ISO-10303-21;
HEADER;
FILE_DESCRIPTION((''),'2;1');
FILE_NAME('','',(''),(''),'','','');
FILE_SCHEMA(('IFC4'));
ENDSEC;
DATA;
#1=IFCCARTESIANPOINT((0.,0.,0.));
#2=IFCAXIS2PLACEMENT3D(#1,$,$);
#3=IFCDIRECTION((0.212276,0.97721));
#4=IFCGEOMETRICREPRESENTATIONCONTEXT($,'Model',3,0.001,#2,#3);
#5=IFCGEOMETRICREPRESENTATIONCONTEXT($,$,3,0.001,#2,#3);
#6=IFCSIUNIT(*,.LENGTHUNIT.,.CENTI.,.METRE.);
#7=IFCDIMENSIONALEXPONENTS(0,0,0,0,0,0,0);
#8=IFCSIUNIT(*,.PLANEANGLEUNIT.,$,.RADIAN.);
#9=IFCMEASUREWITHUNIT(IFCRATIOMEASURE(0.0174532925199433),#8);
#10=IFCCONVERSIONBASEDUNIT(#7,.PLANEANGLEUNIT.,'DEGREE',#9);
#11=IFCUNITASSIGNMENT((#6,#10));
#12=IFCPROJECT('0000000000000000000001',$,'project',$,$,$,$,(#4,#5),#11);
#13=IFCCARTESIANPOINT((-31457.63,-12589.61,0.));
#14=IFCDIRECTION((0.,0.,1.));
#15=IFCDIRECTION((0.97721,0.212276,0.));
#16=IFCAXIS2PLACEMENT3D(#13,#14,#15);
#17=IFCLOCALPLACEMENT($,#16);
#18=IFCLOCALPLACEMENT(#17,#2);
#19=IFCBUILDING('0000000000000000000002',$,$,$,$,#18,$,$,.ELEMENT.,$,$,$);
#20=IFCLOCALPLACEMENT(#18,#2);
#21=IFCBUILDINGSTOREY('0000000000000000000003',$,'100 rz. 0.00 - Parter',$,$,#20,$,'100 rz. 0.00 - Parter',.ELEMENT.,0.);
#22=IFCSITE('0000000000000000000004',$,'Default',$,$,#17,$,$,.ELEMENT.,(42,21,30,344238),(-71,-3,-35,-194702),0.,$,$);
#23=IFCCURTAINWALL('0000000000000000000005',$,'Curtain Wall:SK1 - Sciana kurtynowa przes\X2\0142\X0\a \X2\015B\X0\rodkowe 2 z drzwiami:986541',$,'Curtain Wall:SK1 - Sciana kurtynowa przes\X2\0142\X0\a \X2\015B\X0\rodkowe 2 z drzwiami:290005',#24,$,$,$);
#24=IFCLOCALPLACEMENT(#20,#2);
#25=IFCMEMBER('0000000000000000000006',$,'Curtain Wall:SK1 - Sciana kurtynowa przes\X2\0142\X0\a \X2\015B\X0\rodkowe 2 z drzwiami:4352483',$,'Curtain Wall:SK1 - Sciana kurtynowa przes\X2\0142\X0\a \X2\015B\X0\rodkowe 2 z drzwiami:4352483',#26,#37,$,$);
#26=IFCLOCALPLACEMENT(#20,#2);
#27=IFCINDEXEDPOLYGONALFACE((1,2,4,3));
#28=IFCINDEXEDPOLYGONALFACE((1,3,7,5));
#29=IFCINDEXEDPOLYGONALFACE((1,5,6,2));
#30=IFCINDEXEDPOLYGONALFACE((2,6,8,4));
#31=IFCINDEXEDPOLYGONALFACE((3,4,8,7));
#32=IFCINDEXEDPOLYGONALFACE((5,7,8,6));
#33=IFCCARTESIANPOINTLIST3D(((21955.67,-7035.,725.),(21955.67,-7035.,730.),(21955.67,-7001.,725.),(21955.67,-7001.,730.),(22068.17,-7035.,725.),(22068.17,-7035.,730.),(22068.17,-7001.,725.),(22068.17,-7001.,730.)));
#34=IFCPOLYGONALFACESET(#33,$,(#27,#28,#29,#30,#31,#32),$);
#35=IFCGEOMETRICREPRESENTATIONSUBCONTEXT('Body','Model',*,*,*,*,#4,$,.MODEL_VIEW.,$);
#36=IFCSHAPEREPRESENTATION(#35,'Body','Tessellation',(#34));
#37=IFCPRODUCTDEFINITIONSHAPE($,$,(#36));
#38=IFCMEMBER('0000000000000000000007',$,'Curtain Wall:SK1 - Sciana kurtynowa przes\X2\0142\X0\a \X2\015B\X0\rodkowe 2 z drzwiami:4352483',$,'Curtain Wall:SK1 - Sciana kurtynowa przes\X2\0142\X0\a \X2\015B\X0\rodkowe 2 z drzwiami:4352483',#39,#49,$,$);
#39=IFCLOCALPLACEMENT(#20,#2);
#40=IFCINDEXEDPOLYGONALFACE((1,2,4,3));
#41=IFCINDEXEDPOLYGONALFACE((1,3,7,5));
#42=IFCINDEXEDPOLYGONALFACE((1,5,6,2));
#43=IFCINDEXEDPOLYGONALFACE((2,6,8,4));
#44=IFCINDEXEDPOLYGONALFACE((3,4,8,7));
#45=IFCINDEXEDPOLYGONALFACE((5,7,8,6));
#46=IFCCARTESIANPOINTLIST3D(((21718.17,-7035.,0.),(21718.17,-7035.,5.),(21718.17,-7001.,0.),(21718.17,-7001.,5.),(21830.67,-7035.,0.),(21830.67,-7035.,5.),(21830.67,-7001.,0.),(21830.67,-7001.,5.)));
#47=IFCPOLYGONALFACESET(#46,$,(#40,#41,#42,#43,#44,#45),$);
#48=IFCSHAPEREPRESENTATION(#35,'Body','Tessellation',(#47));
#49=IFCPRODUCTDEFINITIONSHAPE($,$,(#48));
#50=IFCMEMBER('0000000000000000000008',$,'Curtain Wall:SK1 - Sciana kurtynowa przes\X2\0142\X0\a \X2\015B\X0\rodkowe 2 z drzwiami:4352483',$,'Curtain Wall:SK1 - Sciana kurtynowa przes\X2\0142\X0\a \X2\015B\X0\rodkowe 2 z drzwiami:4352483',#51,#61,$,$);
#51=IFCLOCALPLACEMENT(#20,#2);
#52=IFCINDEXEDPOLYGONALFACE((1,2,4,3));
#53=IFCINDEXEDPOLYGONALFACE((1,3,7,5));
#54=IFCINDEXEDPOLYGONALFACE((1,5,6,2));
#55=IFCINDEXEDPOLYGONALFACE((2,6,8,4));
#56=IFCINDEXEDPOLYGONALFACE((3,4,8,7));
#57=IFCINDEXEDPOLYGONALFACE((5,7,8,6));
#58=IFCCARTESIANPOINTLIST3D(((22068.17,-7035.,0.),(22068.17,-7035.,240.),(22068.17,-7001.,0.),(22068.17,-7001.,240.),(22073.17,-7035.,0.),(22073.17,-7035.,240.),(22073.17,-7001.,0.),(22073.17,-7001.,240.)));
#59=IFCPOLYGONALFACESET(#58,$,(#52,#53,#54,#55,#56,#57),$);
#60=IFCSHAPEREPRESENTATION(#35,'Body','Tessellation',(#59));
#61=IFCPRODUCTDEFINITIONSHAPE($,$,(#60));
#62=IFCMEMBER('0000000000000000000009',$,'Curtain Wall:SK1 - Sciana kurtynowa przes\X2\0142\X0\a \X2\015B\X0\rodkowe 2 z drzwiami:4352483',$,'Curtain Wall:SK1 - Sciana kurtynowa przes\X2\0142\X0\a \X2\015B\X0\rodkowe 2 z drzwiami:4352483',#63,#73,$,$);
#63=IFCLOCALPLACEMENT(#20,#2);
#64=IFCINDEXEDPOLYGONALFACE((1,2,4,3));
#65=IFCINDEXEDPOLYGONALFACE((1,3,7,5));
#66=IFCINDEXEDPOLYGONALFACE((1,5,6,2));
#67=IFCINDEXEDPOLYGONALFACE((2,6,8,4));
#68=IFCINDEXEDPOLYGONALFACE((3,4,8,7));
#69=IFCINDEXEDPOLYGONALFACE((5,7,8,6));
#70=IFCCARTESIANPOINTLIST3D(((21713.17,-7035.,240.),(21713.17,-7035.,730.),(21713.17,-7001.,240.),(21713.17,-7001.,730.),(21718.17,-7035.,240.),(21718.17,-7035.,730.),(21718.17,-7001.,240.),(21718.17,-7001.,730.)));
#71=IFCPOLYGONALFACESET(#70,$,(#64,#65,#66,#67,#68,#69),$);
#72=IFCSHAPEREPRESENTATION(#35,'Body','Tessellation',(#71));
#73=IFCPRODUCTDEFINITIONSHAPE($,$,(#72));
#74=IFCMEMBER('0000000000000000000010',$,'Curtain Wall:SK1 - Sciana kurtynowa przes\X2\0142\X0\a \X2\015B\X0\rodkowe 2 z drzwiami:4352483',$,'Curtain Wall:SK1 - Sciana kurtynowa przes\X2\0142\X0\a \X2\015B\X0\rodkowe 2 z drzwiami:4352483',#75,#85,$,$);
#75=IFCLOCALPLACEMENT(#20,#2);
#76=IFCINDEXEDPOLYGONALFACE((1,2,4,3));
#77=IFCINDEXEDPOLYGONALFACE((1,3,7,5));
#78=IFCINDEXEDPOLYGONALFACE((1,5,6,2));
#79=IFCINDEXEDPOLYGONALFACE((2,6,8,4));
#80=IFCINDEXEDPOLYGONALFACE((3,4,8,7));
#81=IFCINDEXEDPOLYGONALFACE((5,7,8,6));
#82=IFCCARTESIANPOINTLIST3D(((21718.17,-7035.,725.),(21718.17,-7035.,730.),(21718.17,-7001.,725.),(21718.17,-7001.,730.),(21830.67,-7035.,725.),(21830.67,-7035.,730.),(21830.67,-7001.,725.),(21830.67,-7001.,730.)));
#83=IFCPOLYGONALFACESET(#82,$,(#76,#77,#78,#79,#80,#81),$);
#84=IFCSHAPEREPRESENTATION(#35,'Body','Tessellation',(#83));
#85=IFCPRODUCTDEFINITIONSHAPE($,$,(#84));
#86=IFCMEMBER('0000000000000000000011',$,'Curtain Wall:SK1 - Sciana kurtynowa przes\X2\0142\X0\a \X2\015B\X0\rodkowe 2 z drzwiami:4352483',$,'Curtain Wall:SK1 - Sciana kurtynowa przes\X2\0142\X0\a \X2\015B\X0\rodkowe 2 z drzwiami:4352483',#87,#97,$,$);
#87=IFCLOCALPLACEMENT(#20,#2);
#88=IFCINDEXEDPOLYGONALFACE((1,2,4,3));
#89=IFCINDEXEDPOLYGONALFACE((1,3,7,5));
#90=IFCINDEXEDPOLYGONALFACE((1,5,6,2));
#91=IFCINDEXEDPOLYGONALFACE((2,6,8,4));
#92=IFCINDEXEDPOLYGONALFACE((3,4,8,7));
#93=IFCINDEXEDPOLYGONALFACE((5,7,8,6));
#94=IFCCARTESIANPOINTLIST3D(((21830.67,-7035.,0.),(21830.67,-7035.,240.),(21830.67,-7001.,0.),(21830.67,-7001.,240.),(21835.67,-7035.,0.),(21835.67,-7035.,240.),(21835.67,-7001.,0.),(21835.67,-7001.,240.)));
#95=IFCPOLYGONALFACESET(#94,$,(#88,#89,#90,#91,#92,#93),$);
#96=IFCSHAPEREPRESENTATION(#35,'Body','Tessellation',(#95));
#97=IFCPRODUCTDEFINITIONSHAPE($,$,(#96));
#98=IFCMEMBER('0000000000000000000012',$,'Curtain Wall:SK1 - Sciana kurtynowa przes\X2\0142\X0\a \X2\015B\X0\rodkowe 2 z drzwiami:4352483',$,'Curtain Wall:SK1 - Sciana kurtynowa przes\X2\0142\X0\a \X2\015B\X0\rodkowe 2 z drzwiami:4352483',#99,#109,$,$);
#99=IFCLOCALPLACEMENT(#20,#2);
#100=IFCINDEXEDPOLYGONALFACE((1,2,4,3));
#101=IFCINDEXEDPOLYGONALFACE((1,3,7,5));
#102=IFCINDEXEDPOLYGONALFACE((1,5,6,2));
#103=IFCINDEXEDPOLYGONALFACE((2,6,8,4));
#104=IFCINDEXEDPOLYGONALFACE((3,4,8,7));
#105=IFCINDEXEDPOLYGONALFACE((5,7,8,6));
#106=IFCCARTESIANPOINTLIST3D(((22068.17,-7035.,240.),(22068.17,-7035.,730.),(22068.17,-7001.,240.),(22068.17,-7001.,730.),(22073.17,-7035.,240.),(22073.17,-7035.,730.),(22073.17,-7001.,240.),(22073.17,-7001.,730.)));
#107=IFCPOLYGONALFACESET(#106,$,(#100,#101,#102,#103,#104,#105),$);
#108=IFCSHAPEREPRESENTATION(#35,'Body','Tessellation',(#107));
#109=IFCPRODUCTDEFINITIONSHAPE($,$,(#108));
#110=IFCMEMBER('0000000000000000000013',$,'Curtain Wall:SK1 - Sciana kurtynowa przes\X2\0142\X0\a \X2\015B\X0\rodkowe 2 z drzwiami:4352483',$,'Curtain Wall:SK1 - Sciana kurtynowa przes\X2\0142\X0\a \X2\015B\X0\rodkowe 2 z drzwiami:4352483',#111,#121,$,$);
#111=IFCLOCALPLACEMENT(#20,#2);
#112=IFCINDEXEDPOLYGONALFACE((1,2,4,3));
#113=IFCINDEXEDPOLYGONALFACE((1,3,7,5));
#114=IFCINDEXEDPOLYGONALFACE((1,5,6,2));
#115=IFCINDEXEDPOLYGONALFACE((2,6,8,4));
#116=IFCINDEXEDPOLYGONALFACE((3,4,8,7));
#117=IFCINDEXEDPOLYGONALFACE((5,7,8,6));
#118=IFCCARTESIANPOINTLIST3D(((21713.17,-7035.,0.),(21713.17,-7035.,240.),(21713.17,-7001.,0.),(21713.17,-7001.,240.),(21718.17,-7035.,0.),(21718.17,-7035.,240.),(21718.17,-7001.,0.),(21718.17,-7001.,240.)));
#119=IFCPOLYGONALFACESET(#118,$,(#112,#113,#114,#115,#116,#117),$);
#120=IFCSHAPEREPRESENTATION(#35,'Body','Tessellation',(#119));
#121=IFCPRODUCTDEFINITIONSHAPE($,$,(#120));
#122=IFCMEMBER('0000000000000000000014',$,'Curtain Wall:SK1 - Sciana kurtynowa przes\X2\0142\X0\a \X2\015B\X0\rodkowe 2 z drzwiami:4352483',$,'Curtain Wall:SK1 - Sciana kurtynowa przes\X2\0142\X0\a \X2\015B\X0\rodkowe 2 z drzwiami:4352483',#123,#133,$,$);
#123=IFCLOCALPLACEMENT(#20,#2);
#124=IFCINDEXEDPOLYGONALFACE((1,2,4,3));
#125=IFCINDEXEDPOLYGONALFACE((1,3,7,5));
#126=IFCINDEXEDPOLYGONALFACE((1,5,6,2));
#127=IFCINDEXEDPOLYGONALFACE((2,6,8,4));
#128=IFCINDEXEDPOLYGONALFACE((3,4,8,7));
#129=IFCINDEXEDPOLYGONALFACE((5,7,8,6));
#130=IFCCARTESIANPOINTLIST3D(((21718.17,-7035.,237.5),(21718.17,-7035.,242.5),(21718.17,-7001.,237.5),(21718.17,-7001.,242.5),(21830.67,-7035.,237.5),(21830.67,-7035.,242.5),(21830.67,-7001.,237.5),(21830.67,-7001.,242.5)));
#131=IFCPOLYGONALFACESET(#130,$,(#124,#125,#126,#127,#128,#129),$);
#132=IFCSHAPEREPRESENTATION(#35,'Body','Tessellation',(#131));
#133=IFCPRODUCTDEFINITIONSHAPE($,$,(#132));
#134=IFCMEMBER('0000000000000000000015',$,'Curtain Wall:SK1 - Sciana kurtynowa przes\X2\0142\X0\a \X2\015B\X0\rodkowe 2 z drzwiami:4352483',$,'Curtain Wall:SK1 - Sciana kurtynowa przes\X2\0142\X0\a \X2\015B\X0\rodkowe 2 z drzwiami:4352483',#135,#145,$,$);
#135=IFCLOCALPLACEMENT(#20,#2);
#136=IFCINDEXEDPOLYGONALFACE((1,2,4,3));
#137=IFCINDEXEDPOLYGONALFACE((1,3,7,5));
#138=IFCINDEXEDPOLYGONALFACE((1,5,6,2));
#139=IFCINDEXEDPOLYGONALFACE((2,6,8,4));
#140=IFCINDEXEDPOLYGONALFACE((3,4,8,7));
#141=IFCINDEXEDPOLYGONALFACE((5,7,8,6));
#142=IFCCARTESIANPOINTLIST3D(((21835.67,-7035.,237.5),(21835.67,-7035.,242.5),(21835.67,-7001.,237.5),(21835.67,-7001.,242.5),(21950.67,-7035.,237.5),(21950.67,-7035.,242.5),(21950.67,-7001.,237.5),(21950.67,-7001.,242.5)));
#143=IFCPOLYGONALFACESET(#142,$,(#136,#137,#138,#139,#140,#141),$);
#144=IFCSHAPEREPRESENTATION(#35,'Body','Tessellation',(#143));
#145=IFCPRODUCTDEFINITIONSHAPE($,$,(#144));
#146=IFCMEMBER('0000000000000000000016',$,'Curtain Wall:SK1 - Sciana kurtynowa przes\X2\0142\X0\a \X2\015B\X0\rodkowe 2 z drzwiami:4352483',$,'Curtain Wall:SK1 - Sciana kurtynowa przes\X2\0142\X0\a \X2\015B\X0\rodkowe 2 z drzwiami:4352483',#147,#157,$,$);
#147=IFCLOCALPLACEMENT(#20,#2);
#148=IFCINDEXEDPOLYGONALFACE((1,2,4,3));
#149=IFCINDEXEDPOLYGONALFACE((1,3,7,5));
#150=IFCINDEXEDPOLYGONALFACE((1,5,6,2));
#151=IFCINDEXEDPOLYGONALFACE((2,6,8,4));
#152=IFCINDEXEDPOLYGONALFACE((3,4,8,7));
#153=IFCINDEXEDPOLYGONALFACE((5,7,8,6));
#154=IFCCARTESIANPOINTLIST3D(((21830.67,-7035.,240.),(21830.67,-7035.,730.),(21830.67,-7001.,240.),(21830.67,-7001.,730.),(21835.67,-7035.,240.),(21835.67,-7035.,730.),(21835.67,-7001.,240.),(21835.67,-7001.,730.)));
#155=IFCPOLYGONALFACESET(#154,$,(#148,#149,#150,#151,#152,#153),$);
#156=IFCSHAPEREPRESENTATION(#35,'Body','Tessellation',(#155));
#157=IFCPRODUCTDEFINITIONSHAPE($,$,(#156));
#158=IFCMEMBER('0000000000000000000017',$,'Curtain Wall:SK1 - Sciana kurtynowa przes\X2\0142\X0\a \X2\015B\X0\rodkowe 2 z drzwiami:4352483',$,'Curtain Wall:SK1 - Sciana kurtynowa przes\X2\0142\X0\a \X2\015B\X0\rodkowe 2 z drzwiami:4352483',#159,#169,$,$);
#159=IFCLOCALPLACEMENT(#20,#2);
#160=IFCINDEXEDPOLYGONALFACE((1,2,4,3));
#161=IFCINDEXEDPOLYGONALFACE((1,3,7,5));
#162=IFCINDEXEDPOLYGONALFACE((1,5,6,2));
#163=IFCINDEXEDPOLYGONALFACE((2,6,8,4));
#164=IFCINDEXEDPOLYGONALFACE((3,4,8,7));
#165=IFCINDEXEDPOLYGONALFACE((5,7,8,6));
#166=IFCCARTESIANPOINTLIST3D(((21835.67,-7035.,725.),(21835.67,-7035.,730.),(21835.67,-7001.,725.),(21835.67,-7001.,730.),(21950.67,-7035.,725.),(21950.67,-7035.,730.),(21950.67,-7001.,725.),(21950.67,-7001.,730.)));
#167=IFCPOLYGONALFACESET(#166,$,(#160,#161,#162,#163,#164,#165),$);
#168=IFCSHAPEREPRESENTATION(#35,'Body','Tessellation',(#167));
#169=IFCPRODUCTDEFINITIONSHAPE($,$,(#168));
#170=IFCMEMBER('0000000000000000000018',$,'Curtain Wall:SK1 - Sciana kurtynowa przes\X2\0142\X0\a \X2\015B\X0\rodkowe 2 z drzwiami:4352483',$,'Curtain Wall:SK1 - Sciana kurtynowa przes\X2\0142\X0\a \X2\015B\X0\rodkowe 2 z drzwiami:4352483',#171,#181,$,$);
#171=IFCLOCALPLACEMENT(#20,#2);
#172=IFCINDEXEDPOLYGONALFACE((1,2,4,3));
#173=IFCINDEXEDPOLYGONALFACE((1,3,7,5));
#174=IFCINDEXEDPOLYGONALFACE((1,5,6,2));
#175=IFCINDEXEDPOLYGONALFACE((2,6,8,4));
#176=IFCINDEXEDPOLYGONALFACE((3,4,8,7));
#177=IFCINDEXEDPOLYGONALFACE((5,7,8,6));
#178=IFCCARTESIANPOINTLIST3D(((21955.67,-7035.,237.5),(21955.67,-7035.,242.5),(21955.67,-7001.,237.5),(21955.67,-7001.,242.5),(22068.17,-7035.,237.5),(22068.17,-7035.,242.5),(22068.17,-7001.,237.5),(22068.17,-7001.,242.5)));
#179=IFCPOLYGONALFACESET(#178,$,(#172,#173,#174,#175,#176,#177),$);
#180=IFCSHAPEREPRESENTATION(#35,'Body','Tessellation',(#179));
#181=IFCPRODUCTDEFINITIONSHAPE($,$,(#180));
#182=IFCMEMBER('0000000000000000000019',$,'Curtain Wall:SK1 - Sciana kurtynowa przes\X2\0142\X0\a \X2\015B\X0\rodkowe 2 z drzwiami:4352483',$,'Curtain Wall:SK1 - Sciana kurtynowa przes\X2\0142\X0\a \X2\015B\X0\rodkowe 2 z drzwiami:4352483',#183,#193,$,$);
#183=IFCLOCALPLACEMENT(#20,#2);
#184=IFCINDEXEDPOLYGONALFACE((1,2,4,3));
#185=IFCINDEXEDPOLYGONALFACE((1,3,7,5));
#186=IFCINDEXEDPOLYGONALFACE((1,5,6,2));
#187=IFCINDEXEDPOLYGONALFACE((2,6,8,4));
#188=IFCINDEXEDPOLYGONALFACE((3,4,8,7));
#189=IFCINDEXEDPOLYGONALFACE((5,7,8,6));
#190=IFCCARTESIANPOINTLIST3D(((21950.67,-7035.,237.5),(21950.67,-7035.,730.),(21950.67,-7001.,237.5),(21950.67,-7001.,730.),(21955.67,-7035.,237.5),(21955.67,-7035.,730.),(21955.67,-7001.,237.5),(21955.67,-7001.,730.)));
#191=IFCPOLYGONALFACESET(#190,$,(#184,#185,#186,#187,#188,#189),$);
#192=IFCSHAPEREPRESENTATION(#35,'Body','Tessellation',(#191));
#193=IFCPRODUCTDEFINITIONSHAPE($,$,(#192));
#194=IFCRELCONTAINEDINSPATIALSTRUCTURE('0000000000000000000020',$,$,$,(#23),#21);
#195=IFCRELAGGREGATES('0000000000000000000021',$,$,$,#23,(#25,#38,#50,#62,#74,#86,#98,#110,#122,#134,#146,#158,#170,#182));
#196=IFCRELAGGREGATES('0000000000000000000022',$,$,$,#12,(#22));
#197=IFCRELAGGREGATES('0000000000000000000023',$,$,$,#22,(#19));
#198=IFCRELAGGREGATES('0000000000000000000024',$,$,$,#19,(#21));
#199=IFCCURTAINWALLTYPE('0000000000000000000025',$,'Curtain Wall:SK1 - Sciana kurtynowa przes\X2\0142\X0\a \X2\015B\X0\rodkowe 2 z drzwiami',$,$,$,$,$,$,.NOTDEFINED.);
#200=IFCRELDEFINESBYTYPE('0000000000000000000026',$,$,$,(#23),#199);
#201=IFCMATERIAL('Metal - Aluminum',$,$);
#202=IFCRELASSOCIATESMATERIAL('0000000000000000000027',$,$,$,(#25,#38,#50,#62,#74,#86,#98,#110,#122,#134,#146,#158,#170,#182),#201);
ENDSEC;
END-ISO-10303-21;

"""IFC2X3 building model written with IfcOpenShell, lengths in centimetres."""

from ifc_helpers import new_model, entity, si_unit, converted_unit, direction, frame, frame_2d, origin, origin_2d_with_axis, place, context, subcontext, project, spatial, rectangle, extrude, material, type_object, element, aggregate, save


model = new_model("IFC2X3")

# Units and contexts
model_context = context("Model", 3, precision=0.001, world=origin(), true_north=direction((0.212276, 0.97721)))
context_of_model = context(None, 3, precision=0.001, world=origin(), true_north=direction((0.212276, 0.97721)))
body_context = subcontext(model_context, "Body", "Model", "MODEL_VIEW")
ifc_project = project(units=[si_unit("LENGTHUNIT", "METRE", prefix="CENTI"), converted_unit("PLANEANGLEUNIT", "DEGREE", entity("IfcRatioMeasure", 0.0174532925199433), si_unit("PLANEANGLEUNIT", "RADIAN"), dimensions=[0, 0, 0, 0, 0, 0, 0])], contexts=[model_context, context_of_model])

# Site, building, storey
site_placement = place(None, frame((-31457.63, -12589.61, 0.0), z_axis=(0.0, 0.0, 1.0), x_axis=(0.97721, 0.212276, 0.0)))
site = spatial("IfcSite", under=ifc_project, at=site_placement, Name="Default", CompositionType="ELEMENT", RefLatitude=(42, 21, 30, 344238), RefLongitude=(-71, -3, -35, -194702), RefElevation=0.0)
building_placement = place(site_placement, origin())
building = spatial("IfcBuilding", under=site, at=building_placement, CompositionType="ELEMENT")
storey_placement = place(building_placement, origin())
storey = spatial("IfcBuildingStorey", under=building, at=storey_placement, Name="100 rz. 0.00 - Parter", LongName="100 rz. 0.00 - Parter", CompositionType="ELEMENT", Elevation=0.0)

# Curtain wall, members
curtain_wall_type = type_object("IfcCurtainWallType", Name="Curtain Wall:SK1 - Sciana kurtynowa przesła środkowe 2 z drzwiami", PredefinedType="NOTDEFINED")
curtain_wall_placement = place(storey_placement, origin())
curtain_wall = element("IfcCurtainWall", 1, at=curtain_wall_placement, inside=storey, type_object=curtain_wall_type, Name="Curtain Wall:SK1 - Sciana kurtynowa przesła środkowe 2 z drzwiami:986541", ObjectType="Curtain Wall:SK1 - Sciana kurtynowa przesła środkowe 2 z drzwiami:290005")
ifc_material_1 = material(Name="Metal - Aluminum")
member_1_placement = place(curtain_wall_placement, frame((21955.67, -7035.0, 725.0)))
member_1 = element("IfcMember", 2, at=member_1_placement, material=ifc_material_1, Name="Curtain Wall:SK1 - Sciana kurtynowa przesła środkowe 2 z drzwiami:4352483", ObjectType="Curtain Wall:SK1 - Sciana kurtynowa przesła środkowe 2 z drzwiami:4352483", context=body_context, shape_type="SweptSolid", body=[
    extrude(rectangle(XDim=112.5, YDim=34.0, at=frame_2d((0.0, 0.0), x_axis=(1.0, 0.0))), frame((56.25, 17.0, 0.0), z_axis=(0.0, 0.0, 1.0), x_axis=(-1.0, 0.0, 0.0)), (0.0, 0.0, 1.0), 5.0),
])
member_2_placement = place(curtain_wall_placement, frame((21718.17, -7035.0, 0.0)))
member_2 = element("IfcMember", 3, at=member_2_placement, material=ifc_material_1, Name="Curtain Wall:SK1 - Sciana kurtynowa przesła środkowe 2 z drzwiami:4352483", ObjectType="Curtain Wall:SK1 - Sciana kurtynowa przesła środkowe 2 z drzwiami:4352483", context=body_context, shape_type="SweptSolid", body=[
    extrude(rectangle(XDim=112.5, YDim=34.0, at=frame_2d((0.0, 0.0), x_axis=(1.0, 0.0))), frame((56.25, 17.0, 0.0)), (0.0, 0.0, 1.0), 5.0),
])
member_3_placement = place(curtain_wall_placement, frame((22068.17, -7035.0, 0.0)))
member_3 = element("IfcMember", 4, at=member_3_placement, material=ifc_material_1, Name="Curtain Wall:SK1 - Sciana kurtynowa przesła środkowe 2 z drzwiami:4352483", ObjectType="Curtain Wall:SK1 - Sciana kurtynowa przesła środkowe 2 z drzwiami:4352483", context=body_context, shape_type="SweptSolid", body=[
    extrude(rectangle(XDim=34.0, YDim=5.0, at=frame_2d((0.0, 0.0), x_axis=(1.0, 0.0))), frame((2.5, 17.0, 0.0), z_axis=(0.0, 0.0, 1.0), x_axis=(0.0, 1.0, 0.0)), (0.0, 0.0, 1.0), 240.0),
])
member_4_placement = place(curtain_wall_placement, frame((21713.17, -7035.0, 240.0)))
member_4 = element("IfcMember", 5, at=member_4_placement, material=ifc_material_1, Name="Curtain Wall:SK1 - Sciana kurtynowa przesła środkowe 2 z drzwiami:4352483", ObjectType="Curtain Wall:SK1 - Sciana kurtynowa przesła środkowe 2 z drzwiami:4352483", context=body_context, shape_type="SweptSolid", body=[
    extrude(rectangle(XDim=5.0, YDim=34.0, at=frame_2d((0.0, 0.0), x_axis=(1.0, 0.0))), frame((2.5, 17.0, 0.0)), (0.0, 0.0, 1.0), 490.0),
])
member_5_placement = place(curtain_wall_placement, frame((21718.17, -7035.0, 725.0)))
member_5 = element("IfcMember", 6, at=member_5_placement, material=ifc_material_1, Name="Curtain Wall:SK1 - Sciana kurtynowa przesła środkowe 2 z drzwiami:4352483", ObjectType="Curtain Wall:SK1 - Sciana kurtynowa przesła środkowe 2 z drzwiami:4352483", context=body_context, shape_type="SweptSolid", body=[
    extrude(rectangle(XDim=112.5, YDim=34.0, at=frame_2d((0.0, 0.0), x_axis=(1.0, 0.0))), frame((56.25, 17.0, 0.0), z_axis=(0.0, 0.0, 1.0), x_axis=(-1.0, 0.0, 0.0)), (0.0, 0.0, 1.0), 5.0),
])
member_6_placement = place(curtain_wall_placement, frame((21830.67, -7035.0, 0.0)))
member_6 = element("IfcMember", 7, at=member_6_placement, material=ifc_material_1, Name="Curtain Wall:SK1 - Sciana kurtynowa przesła środkowe 2 z drzwiami:4352483", ObjectType="Curtain Wall:SK1 - Sciana kurtynowa przesła środkowe 2 z drzwiami:4352483", context=body_context, shape_type="SweptSolid", body=[
    extrude(rectangle(XDim=34.0, YDim=5.0, at=frame_2d((0.0, 0.0), x_axis=(1.0, 0.0))), frame((2.5, 17.0, 0.0), z_axis=(0.0, 0.0, 1.0), x_axis=(0.0, 1.0, 0.0)), (0.0, 0.0, 1.0), 240.0),
])
member_7_placement = place(curtain_wall_placement, frame((22068.17, -7035.0, 240.0)))
member_7 = element("IfcMember", 8, at=member_7_placement, material=ifc_material_1, Name="Curtain Wall:SK1 - Sciana kurtynowa przesła środkowe 2 z drzwiami:4352483", ObjectType="Curtain Wall:SK1 - Sciana kurtynowa przesła środkowe 2 z drzwiami:4352483", context=body_context, shape_type="SweptSolid", body=[
    extrude(rectangle(XDim=34.0, YDim=5.0, at=frame_2d((0.0, 0.0), x_axis=(1.0, 0.0))), frame((2.5, 17.0, 0.0), z_axis=(0.0, 0.0, 1.0), x_axis=(0.0, 1.0, 0.0)), (0.0, 0.0, 1.0), 490.0),
])
member_8_placement = place(curtain_wall_placement, frame((21713.17, -7035.0, 0.0)))
member_8 = element("IfcMember", 9, at=member_8_placement, material=ifc_material_1, Name="Curtain Wall:SK1 - Sciana kurtynowa przesła środkowe 2 z drzwiami:4352483", ObjectType="Curtain Wall:SK1 - Sciana kurtynowa przesła środkowe 2 z drzwiami:4352483", context=body_context, shape_type="SweptSolid", body=[
    extrude(rectangle(XDim=5.0, YDim=34.0, at=frame_2d((0.0, 0.0), x_axis=(1.0, 0.0))), frame((2.5, 17.0, 0.0)), (0.0, 0.0, 1.0), 240.0),
])
member_9_placement = place(curtain_wall_placement, frame((21718.17, -7035.0, 237.5)))
member_9 = element("IfcMember", 10, at=member_9_placement, material=ifc_material_1, Name="Curtain Wall:SK1 - Sciana kurtynowa przesła środkowe 2 z drzwiami:4352483", ObjectType="Curtain Wall:SK1 - Sciana kurtynowa przesła środkowe 2 z drzwiami:4352483", context=body_context, shape_type="SweptSolid", body=[
    extrude(rectangle(XDim=112.5, YDim=34.0, at=origin_2d_with_axis()), frame((56.25, 17.0, 0.0), z_axis=(0.0, 0.0, 1.0), x_axis=(-1.0, 0.0, 0.0)), (0.0, 0.0, 1.0), 5.0),
])
member_10_placement = place(curtain_wall_placement, frame((21835.67, -7035.0, 237.5)))
member_10 = element("IfcMember", 11, at=member_10_placement, material=ifc_material_1, Name="Curtain Wall:SK1 - Sciana kurtynowa przesła środkowe 2 z drzwiami:4352483", ObjectType="Curtain Wall:SK1 - Sciana kurtynowa przesła środkowe 2 z drzwiami:4352483", context=body_context, shape_type="SweptSolid", body=[
    extrude(rectangle(XDim=115.0, YDim=34.0, at=frame_2d((0.0, 0.0), x_axis=(1.0, 0.0))), frame((57.5, 17.0, 0.0), z_axis=(0.0, 0.0, 1.0), x_axis=(-1.0, 0.0, 0.0)), (0.0, 0.0, 1.0), 5.0),
])
member_11_placement = place(curtain_wall_placement, frame((21830.67, -7035.0, 240.0)))
member_11 = element("IfcMember", 12, at=member_11_placement, material=ifc_material_1, Name="Curtain Wall:SK1 - Sciana kurtynowa przesła środkowe 2 z drzwiami:4352483", ObjectType="Curtain Wall:SK1 - Sciana kurtynowa przesła środkowe 2 z drzwiami:4352483", context=body_context, shape_type="SweptSolid", body=[
    extrude(rectangle(XDim=34.0, YDim=5.0, at=frame_2d((0.0, 0.0), x_axis=(1.0, 0.0))), frame((2.5, 17.0, 0.0), z_axis=(0.0, 0.0, 1.0), x_axis=(0.0, 1.0, 0.0)), (0.0, 0.0, 1.0), 490.0),
])
member_12_placement = place(curtain_wall_placement, frame((21835.67, -7035.0, 725.0)))
member_12 = element("IfcMember", 13, at=member_12_placement, material=ifc_material_1, Name="Curtain Wall:SK1 - Sciana kurtynowa przesła środkowe 2 z drzwiami:4352483", ObjectType="Curtain Wall:SK1 - Sciana kurtynowa przesła środkowe 2 z drzwiami:4352483", context=body_context, shape_type="SweptSolid", body=[
    extrude(rectangle(XDim=115.0, YDim=34.0, at=frame_2d((0.0, 0.0), x_axis=(1.0, 0.0))), frame((57.5, 17.0, 0.0), z_axis=(0.0, 0.0, 1.0), x_axis=(-1.0, 0.0, 0.0)), (0.0, 0.0, 1.0), 5.0),
])
member_13_placement = place(curtain_wall_placement, frame((21955.67, -7035.0, 237.5)))
member_13 = element("IfcMember", 14, at=member_13_placement, material=ifc_material_1, Name="Curtain Wall:SK1 - Sciana kurtynowa przesła środkowe 2 z drzwiami:4352483", ObjectType="Curtain Wall:SK1 - Sciana kurtynowa przesła środkowe 2 z drzwiami:4352483", context=body_context, shape_type="SweptSolid", body=[
    extrude(rectangle(XDim=112.5, YDim=34.0, at=origin_2d_with_axis()), frame((56.25, 17.0, 0.0), z_axis=(0.0, 0.0, 1.0), x_axis=(-1.0, 0.0, 0.0)), (0.0, 0.0, 1.0), 5.0),
])
member_14_placement = place(curtain_wall_placement, frame((21950.67, -7035.0, 237.5)))
member_14 = element("IfcMember", 15, at=member_14_placement, material=ifc_material_1, Name="Curtain Wall:SK1 - Sciana kurtynowa przesła środkowe 2 z drzwiami:4352483", ObjectType="Curtain Wall:SK1 - Sciana kurtynowa przesła środkowe 2 z drzwiami:4352483", context=body_context, shape_type="SweptSolid", body=[
    extrude(rectangle(XDim=34.0, YDim=5.0, at=frame_2d((0.0, 0.0), x_axis=(1.0, 0.0))), frame((2.5, 17.0, 0.0), z_axis=(0.0, 0.0, 1.0), x_axis=(0.0, 1.0, 0.0)), (0.0, 0.0, 1.0), 492.5),
])

aggregate(curtain_wall, [member_1, member_2, member_3, member_4, member_5, member_6, member_7, member_8, member_9, member_10, member_11, member_12, member_13, member_14])

save(model, "model.ifc")
